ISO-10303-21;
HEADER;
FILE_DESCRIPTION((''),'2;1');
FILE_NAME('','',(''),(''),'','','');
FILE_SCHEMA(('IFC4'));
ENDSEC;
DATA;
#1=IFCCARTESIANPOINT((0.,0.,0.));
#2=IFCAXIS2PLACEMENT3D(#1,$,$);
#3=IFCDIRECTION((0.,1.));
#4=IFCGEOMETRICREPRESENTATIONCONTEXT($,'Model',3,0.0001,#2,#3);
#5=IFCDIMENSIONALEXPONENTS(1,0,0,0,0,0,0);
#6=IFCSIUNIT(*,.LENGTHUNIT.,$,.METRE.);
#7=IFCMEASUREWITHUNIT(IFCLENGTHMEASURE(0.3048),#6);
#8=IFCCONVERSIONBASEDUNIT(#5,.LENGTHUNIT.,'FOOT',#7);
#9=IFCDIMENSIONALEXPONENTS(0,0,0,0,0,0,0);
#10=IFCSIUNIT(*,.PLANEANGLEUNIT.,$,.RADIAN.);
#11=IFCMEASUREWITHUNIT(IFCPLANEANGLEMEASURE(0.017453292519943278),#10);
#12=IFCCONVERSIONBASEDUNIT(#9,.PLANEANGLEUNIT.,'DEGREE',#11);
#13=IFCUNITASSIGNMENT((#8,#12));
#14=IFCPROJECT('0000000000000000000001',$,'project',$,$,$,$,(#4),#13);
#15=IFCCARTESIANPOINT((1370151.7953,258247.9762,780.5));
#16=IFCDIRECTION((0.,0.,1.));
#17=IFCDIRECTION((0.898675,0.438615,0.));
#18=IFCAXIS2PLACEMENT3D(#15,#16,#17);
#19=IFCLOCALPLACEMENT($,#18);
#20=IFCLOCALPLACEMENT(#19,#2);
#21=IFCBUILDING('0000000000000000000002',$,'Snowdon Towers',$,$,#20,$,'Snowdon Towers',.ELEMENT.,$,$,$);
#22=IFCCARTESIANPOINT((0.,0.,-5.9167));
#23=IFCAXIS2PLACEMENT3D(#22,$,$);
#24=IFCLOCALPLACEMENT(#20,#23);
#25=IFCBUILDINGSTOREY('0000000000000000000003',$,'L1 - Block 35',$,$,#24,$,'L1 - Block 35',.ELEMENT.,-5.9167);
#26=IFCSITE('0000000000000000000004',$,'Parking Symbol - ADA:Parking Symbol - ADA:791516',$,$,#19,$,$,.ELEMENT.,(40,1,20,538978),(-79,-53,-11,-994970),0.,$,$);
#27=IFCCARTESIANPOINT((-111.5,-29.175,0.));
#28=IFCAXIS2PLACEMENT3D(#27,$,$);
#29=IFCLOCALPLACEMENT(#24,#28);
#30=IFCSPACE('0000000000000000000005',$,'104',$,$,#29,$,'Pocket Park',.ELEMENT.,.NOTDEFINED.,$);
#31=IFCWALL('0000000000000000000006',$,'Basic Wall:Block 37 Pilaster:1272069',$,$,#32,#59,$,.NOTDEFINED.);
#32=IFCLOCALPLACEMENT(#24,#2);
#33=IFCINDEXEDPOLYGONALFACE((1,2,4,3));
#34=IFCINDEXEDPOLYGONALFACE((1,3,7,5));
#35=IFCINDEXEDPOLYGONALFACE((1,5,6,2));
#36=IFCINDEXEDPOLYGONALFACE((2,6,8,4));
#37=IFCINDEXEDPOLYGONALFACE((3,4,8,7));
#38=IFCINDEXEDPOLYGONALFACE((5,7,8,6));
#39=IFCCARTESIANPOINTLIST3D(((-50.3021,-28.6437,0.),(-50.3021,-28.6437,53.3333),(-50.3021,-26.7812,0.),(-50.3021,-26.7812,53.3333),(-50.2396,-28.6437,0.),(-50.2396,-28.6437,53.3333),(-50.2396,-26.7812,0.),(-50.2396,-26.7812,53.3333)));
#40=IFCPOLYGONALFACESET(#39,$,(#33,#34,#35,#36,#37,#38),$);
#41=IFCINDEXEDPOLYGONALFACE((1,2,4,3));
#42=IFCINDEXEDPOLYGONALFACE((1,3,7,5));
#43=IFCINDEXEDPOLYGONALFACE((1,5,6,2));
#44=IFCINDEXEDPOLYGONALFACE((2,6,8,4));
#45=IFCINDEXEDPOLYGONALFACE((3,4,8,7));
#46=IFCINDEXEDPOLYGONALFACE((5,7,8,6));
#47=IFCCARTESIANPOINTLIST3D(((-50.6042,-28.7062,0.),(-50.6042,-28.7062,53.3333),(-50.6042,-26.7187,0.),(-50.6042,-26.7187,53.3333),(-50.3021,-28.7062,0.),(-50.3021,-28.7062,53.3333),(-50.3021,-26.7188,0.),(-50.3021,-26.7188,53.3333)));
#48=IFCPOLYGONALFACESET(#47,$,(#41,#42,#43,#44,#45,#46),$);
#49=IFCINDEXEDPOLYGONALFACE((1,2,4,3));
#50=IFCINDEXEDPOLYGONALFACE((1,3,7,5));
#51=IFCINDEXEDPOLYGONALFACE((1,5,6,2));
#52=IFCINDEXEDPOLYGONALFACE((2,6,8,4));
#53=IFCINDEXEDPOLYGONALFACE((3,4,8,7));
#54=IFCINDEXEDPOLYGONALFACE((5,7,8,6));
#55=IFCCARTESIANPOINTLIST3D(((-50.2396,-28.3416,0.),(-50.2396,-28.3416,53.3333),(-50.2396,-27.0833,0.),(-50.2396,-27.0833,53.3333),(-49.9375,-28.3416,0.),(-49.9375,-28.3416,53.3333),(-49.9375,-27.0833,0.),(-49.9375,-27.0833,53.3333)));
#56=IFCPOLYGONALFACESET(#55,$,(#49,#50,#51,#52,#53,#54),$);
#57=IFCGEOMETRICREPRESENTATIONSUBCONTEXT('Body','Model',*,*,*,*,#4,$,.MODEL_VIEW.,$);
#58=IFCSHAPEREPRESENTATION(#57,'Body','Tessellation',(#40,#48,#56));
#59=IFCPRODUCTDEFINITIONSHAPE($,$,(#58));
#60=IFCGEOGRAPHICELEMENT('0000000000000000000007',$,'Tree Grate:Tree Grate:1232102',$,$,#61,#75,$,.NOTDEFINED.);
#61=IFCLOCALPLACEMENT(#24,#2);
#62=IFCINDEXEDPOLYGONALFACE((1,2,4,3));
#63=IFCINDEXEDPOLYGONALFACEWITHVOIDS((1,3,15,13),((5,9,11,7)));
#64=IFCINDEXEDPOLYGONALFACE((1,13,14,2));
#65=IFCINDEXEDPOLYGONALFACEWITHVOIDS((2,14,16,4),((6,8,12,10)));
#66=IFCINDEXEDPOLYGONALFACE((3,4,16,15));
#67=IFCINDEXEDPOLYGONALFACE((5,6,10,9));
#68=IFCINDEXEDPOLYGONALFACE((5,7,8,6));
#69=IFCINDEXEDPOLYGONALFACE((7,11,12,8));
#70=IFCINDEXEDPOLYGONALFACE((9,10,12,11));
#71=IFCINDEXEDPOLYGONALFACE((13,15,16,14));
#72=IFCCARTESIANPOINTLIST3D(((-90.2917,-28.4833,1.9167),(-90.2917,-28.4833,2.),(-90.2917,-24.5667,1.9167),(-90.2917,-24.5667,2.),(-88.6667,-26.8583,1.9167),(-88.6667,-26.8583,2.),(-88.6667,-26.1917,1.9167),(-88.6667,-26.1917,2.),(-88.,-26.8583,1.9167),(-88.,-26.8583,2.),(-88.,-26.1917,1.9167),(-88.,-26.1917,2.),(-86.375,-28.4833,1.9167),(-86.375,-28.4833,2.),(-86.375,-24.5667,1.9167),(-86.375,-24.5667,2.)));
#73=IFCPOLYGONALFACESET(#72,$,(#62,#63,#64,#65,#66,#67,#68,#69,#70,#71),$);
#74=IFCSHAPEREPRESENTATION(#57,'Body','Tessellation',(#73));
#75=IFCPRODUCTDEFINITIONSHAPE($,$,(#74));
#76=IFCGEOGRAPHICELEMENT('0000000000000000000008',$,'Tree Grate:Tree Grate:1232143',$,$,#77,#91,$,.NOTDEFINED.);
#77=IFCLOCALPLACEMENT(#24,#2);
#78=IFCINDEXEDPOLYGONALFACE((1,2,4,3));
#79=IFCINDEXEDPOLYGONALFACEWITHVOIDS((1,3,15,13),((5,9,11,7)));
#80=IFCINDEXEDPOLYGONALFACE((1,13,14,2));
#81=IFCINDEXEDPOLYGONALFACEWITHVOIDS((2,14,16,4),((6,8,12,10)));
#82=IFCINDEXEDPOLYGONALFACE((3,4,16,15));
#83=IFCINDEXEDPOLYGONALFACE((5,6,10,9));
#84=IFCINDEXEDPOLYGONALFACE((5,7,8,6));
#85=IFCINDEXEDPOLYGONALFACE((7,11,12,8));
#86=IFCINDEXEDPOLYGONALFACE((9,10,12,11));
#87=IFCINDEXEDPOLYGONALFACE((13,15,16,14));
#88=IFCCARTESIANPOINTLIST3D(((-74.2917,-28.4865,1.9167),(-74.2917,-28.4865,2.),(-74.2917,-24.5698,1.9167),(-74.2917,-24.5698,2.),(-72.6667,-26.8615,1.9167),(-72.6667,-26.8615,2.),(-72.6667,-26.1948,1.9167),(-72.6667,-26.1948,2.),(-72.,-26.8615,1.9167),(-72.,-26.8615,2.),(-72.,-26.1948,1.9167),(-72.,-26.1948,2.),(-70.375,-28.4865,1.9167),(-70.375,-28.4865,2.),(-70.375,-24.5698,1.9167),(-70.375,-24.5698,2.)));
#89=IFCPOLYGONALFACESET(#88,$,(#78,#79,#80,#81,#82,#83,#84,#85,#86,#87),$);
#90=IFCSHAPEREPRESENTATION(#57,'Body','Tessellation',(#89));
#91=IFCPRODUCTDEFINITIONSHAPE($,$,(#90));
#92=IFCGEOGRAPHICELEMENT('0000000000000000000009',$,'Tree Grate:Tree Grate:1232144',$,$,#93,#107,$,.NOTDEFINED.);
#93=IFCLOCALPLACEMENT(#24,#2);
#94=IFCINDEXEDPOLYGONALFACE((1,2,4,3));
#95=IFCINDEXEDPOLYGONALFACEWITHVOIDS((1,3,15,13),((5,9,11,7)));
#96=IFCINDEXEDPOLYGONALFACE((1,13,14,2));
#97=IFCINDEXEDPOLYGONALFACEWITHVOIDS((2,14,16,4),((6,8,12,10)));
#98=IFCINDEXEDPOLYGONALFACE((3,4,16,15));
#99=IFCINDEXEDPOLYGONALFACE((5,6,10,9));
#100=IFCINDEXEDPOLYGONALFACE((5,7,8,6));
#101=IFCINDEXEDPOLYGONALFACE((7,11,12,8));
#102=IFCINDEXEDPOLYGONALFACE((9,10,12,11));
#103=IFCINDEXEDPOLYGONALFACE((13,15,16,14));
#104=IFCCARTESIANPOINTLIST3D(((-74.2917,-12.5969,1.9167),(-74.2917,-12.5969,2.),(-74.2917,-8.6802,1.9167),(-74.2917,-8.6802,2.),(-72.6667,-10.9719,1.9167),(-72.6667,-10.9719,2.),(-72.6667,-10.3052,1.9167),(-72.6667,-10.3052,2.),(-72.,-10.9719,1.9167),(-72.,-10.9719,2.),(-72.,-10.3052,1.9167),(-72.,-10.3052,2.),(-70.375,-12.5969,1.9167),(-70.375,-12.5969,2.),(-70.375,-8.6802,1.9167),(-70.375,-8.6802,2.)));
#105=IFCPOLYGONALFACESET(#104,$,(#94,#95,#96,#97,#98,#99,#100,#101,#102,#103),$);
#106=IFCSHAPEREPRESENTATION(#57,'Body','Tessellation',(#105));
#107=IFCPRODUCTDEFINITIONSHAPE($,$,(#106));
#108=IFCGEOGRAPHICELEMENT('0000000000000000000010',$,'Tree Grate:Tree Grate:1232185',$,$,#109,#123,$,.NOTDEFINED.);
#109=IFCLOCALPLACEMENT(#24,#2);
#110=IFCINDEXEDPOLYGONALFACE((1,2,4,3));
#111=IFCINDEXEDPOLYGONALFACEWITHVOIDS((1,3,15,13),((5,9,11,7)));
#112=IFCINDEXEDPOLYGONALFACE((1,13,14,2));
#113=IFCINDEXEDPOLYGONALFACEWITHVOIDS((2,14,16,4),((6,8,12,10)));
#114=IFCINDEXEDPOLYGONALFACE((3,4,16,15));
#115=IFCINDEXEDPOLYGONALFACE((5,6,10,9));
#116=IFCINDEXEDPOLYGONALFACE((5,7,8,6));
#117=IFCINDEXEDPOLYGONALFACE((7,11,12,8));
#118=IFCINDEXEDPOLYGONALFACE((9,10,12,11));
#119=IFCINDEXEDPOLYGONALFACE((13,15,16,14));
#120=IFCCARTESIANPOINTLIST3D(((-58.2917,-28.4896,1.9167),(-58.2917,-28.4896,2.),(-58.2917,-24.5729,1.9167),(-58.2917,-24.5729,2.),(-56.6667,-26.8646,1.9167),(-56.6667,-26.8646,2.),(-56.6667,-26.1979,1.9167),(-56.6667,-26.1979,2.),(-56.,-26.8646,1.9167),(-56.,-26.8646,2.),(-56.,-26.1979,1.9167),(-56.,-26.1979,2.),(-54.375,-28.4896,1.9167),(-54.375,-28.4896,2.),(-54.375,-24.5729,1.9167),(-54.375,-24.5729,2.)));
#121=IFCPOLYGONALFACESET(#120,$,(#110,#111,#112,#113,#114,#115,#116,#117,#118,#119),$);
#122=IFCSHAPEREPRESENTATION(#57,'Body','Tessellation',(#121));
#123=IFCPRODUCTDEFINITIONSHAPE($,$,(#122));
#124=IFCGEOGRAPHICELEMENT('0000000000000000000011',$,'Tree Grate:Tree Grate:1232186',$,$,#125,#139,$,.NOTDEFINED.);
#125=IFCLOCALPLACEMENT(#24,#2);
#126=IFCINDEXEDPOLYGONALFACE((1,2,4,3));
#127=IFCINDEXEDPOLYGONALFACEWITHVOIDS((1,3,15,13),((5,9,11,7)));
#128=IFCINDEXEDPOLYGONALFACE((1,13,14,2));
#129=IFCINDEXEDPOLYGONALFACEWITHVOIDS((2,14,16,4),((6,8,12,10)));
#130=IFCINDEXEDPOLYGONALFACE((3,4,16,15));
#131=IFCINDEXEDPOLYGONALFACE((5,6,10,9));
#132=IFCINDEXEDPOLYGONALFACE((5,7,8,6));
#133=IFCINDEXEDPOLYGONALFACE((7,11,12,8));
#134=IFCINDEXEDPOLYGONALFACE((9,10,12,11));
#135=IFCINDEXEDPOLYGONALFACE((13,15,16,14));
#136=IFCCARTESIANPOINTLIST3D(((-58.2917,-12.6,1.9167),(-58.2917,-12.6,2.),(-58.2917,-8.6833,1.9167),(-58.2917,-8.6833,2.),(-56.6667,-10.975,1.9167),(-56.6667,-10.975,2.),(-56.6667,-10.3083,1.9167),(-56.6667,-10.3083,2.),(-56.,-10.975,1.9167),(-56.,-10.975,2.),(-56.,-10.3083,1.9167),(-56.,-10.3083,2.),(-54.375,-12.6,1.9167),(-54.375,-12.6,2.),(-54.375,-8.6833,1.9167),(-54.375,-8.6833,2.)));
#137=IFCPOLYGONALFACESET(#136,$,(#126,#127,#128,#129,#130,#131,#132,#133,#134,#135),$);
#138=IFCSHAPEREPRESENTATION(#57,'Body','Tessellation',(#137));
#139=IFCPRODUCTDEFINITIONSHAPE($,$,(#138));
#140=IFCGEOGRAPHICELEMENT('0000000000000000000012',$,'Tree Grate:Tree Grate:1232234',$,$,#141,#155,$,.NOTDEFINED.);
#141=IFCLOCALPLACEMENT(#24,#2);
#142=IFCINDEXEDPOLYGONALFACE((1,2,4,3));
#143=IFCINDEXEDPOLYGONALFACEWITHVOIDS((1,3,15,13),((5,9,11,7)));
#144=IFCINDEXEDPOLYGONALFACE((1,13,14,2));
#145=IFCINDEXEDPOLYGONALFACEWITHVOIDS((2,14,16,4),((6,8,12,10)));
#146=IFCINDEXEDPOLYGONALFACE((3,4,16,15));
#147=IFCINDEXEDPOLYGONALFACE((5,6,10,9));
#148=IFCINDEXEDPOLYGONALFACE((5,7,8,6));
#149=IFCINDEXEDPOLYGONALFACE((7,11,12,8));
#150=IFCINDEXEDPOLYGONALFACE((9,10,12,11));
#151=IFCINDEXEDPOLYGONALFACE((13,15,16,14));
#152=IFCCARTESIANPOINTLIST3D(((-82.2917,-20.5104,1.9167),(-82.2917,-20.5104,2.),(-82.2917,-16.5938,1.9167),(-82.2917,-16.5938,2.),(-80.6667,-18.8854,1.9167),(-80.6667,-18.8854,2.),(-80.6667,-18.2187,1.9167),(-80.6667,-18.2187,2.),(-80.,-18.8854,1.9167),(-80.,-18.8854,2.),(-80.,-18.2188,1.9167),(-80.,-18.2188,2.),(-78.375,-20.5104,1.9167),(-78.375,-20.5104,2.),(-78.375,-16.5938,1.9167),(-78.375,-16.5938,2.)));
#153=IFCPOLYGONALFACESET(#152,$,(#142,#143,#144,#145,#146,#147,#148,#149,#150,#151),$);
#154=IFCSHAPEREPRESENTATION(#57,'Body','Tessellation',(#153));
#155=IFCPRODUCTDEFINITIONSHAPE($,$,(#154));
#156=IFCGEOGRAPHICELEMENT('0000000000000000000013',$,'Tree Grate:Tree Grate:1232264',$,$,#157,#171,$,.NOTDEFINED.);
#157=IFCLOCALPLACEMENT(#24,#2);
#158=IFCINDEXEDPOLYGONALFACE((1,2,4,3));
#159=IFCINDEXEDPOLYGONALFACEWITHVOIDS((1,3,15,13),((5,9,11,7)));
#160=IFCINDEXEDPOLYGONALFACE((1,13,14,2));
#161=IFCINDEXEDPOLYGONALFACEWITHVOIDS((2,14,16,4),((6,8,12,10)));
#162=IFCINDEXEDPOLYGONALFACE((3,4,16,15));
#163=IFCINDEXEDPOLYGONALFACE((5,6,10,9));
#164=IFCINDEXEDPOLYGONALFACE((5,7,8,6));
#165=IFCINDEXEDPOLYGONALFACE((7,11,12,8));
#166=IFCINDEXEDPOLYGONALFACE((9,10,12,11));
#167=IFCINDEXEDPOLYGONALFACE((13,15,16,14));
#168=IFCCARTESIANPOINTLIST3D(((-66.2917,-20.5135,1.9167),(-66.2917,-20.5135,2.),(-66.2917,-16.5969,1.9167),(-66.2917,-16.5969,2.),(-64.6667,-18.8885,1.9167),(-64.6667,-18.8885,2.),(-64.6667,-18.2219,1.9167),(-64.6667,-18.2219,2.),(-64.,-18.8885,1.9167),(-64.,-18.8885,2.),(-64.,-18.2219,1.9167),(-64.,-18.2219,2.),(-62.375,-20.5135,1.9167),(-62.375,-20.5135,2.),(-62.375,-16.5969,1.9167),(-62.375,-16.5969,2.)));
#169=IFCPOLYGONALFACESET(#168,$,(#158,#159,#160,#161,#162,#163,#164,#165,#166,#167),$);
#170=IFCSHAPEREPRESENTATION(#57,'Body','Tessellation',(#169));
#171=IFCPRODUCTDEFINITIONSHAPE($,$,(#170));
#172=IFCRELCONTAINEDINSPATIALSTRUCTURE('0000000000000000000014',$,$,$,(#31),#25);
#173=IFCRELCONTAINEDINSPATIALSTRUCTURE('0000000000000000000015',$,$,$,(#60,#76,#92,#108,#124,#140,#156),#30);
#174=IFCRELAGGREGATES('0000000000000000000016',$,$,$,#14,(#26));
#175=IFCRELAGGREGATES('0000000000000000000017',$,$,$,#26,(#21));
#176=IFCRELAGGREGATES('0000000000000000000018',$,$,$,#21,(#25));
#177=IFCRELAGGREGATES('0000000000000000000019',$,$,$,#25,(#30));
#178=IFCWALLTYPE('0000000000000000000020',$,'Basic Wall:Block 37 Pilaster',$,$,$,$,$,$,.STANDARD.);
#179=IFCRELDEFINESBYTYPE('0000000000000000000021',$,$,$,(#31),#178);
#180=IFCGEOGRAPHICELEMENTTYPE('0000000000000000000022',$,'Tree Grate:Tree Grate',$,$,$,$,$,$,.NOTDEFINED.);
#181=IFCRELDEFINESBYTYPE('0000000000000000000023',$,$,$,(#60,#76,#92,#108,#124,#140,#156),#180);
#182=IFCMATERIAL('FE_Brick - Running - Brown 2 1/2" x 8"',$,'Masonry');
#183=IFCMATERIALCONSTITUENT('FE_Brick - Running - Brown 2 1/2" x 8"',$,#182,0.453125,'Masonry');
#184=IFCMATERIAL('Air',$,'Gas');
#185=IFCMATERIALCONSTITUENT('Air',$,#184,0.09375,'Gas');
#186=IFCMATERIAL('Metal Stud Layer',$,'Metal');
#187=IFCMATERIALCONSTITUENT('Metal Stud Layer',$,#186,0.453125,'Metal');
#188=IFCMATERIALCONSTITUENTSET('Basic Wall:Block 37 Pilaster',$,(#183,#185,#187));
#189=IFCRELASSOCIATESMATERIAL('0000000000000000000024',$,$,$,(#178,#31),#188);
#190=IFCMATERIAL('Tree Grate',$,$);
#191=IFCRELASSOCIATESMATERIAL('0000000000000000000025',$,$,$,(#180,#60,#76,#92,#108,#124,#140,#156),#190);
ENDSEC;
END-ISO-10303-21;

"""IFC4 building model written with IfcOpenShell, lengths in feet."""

from ifc_helpers import new_model, entity, si_unit, converted_unit, direction, frame, origin, place, context, subcontext, project, spatial, indexed_curve, outline, extrude, source, transform, mapped, material, constituent, constituent_set, type_object, type_shapes, element, save


model = new_model("IFC4")

# Units and contexts
model_context = context("Model", 3, precision=0.0001, world=origin(), true_north=direction((0.0, 1.0)))
body_context = subcontext(model_context, "Body", "Model", "MODEL_VIEW")
ifc_project = project(units=[converted_unit("LENGTHUNIT", "FOOT", entity("IfcLengthMeasure", 0.3048), si_unit("LENGTHUNIT", "METRE"), dimensions=[1, 0, 0, 0, 0, 0, 0]), converted_unit("PLANEANGLEUNIT", "DEGREE", entity("IfcPlaneAngleMeasure", 0.017453292519943278), si_unit("PLANEANGLEUNIT", "RADIAN"), dimensions=[0, 0, 0, 0, 0, 0, 0])], contexts=[model_context])

# Site, building, storey
site_placement = place(None, frame((1370151.7953, 258247.9762, 780.5), z_axis=(0.0, 0.0, 1.0), x_axis=(0.898675, 0.438615, 0.0)))
site = spatial("IfcSite", under=ifc_project, at=site_placement, Name="Parking Symbol - ADA:Parking Symbol - ADA:791516", CompositionType="ELEMENT", RefLatitude=(40, 1, 20, 538978), RefLongitude=(-79, -53, -11, -994970), RefElevation=0.0)
building_placement = place(site_placement, origin())
building = spatial("IfcBuilding", under=site, at=building_placement, Name="Snowdon Towers", LongName="Snowdon Towers", CompositionType="ELEMENT")
storey_placement = place(building_placement, frame((0.0, 0.0, -5.9167)))
storey = spatial("IfcBuildingStorey", under=building, at=storey_placement, Name="L1 - Block 35", LongName="L1 - Block 35", CompositionType="ELEMENT", Elevation=-5.9167)

# Wall
ifc_material_1 = material(Name="FE_Brick - Running - Brown 2 1/2\" x 8\"", Category="Masonry")
ifc_constituent_1 = constituent(ifc_material_1, Name="FE_Brick - Running - Brown 2 1/2\" x 8\"", Category="Masonry", fraction=0.453125)
ifc_material_2 = material(Name="Air", Category="Gas")
ifc_constituent_2 = constituent(ifc_material_2, Name="Air", Category="Gas", fraction=0.09375)
ifc_material_3 = material(Name="Metal Stud Layer", Category="Metal")
ifc_constituent_3 = constituent(ifc_material_3, Name="Metal Stud Layer", Category="Metal", fraction=0.453125)
ifc_constituent_set_1 = constituent_set(constituents=[ifc_constituent_1, ifc_constituent_2, ifc_constituent_3], Name="Basic Wall:Block 37 Pilaster")
wall_type = type_object("IfcWallType", Name="Basic Wall:Block 37 Pilaster", PredefinedType="STANDARD", material=ifc_constituent_set_1)
wall_1_placement = place(storey_placement, frame((-50.2708, -27.0833, 0.0), z_axis=(0.0, 0.0, 1.0), x_axis=(0.0, -1.0, 0.0)))
element("IfcWall", 1, at=wall_1_placement, inside=storey, type_object=wall_type, material=ifc_constituent_set_1, Name="Basic Wall:Block 37 Pilaster:1272069", PredefinedType="NOTDEFINED", context=body_context, shape_type="SweptSolid", body=[
    extrude(outline(indexed_curve([(-0.0312, -0.9312), (0.0312, -0.9312), (0.0312, 0.9312), (-0.0312, 0.9312), (-0.0312, -0.9312)], self_intersect=False)), frame((0.6292, 0.0, 0.0), z_axis=(0.0, 0.0, 1.0), x_axis=(0.0, 1.0, 0.0)), (0.0, 0.0, 1.0), 53.3333),
    extrude(outline(indexed_curve([(-0.151, -0.9937), (0.151, -0.9937), (0.151, 0.9937), (-0.151, 0.9937), (-0.151, -0.9937)], self_intersect=False)), frame((0.6292, -0.1823, 0.0), z_axis=(0.0, 0.0, 1.0), x_axis=(0.0, -1.0, 0.0)), (0.0, 0.0, 1.0), 53.3333),
    extrude(outline(indexed_curve([(-0.151, -0.6292), (0.151, -0.6292), (0.151, 0.6292), (-0.151, 0.6292), (-0.151, -0.6292)], self_intersect=False)), frame((0.6292, 0.1823, 0.0), z_axis=(0.0, 0.0, 1.0), x_axis=(0.0, 1.0, 0.0)), (0.0, 0.0, 1.0), 53.3333),
])

# Shared definitions
space_placement = place(storey_placement, frame((-111.5, -29.175, 0.0)))
space = spatial("IfcSpace", under=storey, at=space_placement, Name="104", LongName="Pocket Park", CompositionType="ELEMENT", PredefinedType="NOTDEFINED")

# Geographic elements
ifc_material_4 = material(Name="Tree Grate")
geographic_element_type_1 = type_object("IfcGeographicElementType", Name="Tree Grate:Tree Grate", PredefinedType="NOTDEFINED", material=ifc_material_4)
shared_shape_1 = source(origin(), body_context, "Body", "SweptSolid", [
    extrude(outline(indexed_curve([(-1.9583, -1.9583), (1.9583, -1.9583), (1.9583, 1.9583), (-1.9583, 1.9583), (-1.9583, -1.9583)], self_intersect=False), holes=[indexed_curve([(-0.3333, -0.3333), (-0.3333, 0.3333), (0.3333, 0.3333), (0.3333, -0.3333), (-0.3333, -0.3333)], self_intersect=False)]), frame((0.0, 0.0, -0.0833), z_axis=(0.0, 0.0, 1.0), x_axis=(-1.0, 0.0, 0.0)), (0.0, 0.0, 1.0), 0.0833),
])
type_shapes(geographic_element_type_1, [shared_shape_1])
for number, where, z_axis, x_axis, name in (
    (2, (23.1667, 2.65, 2.0), (0.0, 0.0, 1.0), (0.0, 1.0, 0.0), "Tree Grate:Tree Grate:1232102"),
    (3, (39.1667, 2.6468, 2.0), (0.0, 0.0, 1.0), (0.0, 1.0, 0.0), "Tree Grate:Tree Grate:1232143"),
    (4, (39.1667, 18.5364, 2.0), (0.0, 0.0, 1.0), (0.0, 1.0, 0.0), "Tree Grate:Tree Grate:1232144"),
    (5, (55.1667, 2.6437, 2.0), (0.0, 0.0, 1.0), (0.0, 1.0, 0.0), "Tree Grate:Tree Grate:1232185"),
    (6, (55.1667, 18.5333, 2.0), (0.0, 0.0, 1.0), (0.0, 1.0, 0.0), "Tree Grate:Tree Grate:1232186"),
    (7, (31.1667, 10.6229, 2.0), (0.0, 0.0, 1.0), (0.0, 1.0, 0.0), "Tree Grate:Tree Grate:1232234"),
    (8, (47.1667, 10.6198, 2.0), (0.0, 0.0, 1.0), (0.0, 1.0, 0.0), "Tree Grate:Tree Grate:1232264"),
):
    element("IfcGeographicElement", number, at=place(space_placement, frame(where, z_axis=z_axis, x_axis=x_axis)), inside=space, type_object=geographic_element_type_1, material=ifc_material_4, Name=name, PredefinedType="NOTDEFINED", context=body_context, shape_type="MappedRepresentation", body=[
        mapped(shared_shape_1, transform((0.0, 0.0, 0.0), scale=1.0)),
    ])

save(model, "model.ifc")
